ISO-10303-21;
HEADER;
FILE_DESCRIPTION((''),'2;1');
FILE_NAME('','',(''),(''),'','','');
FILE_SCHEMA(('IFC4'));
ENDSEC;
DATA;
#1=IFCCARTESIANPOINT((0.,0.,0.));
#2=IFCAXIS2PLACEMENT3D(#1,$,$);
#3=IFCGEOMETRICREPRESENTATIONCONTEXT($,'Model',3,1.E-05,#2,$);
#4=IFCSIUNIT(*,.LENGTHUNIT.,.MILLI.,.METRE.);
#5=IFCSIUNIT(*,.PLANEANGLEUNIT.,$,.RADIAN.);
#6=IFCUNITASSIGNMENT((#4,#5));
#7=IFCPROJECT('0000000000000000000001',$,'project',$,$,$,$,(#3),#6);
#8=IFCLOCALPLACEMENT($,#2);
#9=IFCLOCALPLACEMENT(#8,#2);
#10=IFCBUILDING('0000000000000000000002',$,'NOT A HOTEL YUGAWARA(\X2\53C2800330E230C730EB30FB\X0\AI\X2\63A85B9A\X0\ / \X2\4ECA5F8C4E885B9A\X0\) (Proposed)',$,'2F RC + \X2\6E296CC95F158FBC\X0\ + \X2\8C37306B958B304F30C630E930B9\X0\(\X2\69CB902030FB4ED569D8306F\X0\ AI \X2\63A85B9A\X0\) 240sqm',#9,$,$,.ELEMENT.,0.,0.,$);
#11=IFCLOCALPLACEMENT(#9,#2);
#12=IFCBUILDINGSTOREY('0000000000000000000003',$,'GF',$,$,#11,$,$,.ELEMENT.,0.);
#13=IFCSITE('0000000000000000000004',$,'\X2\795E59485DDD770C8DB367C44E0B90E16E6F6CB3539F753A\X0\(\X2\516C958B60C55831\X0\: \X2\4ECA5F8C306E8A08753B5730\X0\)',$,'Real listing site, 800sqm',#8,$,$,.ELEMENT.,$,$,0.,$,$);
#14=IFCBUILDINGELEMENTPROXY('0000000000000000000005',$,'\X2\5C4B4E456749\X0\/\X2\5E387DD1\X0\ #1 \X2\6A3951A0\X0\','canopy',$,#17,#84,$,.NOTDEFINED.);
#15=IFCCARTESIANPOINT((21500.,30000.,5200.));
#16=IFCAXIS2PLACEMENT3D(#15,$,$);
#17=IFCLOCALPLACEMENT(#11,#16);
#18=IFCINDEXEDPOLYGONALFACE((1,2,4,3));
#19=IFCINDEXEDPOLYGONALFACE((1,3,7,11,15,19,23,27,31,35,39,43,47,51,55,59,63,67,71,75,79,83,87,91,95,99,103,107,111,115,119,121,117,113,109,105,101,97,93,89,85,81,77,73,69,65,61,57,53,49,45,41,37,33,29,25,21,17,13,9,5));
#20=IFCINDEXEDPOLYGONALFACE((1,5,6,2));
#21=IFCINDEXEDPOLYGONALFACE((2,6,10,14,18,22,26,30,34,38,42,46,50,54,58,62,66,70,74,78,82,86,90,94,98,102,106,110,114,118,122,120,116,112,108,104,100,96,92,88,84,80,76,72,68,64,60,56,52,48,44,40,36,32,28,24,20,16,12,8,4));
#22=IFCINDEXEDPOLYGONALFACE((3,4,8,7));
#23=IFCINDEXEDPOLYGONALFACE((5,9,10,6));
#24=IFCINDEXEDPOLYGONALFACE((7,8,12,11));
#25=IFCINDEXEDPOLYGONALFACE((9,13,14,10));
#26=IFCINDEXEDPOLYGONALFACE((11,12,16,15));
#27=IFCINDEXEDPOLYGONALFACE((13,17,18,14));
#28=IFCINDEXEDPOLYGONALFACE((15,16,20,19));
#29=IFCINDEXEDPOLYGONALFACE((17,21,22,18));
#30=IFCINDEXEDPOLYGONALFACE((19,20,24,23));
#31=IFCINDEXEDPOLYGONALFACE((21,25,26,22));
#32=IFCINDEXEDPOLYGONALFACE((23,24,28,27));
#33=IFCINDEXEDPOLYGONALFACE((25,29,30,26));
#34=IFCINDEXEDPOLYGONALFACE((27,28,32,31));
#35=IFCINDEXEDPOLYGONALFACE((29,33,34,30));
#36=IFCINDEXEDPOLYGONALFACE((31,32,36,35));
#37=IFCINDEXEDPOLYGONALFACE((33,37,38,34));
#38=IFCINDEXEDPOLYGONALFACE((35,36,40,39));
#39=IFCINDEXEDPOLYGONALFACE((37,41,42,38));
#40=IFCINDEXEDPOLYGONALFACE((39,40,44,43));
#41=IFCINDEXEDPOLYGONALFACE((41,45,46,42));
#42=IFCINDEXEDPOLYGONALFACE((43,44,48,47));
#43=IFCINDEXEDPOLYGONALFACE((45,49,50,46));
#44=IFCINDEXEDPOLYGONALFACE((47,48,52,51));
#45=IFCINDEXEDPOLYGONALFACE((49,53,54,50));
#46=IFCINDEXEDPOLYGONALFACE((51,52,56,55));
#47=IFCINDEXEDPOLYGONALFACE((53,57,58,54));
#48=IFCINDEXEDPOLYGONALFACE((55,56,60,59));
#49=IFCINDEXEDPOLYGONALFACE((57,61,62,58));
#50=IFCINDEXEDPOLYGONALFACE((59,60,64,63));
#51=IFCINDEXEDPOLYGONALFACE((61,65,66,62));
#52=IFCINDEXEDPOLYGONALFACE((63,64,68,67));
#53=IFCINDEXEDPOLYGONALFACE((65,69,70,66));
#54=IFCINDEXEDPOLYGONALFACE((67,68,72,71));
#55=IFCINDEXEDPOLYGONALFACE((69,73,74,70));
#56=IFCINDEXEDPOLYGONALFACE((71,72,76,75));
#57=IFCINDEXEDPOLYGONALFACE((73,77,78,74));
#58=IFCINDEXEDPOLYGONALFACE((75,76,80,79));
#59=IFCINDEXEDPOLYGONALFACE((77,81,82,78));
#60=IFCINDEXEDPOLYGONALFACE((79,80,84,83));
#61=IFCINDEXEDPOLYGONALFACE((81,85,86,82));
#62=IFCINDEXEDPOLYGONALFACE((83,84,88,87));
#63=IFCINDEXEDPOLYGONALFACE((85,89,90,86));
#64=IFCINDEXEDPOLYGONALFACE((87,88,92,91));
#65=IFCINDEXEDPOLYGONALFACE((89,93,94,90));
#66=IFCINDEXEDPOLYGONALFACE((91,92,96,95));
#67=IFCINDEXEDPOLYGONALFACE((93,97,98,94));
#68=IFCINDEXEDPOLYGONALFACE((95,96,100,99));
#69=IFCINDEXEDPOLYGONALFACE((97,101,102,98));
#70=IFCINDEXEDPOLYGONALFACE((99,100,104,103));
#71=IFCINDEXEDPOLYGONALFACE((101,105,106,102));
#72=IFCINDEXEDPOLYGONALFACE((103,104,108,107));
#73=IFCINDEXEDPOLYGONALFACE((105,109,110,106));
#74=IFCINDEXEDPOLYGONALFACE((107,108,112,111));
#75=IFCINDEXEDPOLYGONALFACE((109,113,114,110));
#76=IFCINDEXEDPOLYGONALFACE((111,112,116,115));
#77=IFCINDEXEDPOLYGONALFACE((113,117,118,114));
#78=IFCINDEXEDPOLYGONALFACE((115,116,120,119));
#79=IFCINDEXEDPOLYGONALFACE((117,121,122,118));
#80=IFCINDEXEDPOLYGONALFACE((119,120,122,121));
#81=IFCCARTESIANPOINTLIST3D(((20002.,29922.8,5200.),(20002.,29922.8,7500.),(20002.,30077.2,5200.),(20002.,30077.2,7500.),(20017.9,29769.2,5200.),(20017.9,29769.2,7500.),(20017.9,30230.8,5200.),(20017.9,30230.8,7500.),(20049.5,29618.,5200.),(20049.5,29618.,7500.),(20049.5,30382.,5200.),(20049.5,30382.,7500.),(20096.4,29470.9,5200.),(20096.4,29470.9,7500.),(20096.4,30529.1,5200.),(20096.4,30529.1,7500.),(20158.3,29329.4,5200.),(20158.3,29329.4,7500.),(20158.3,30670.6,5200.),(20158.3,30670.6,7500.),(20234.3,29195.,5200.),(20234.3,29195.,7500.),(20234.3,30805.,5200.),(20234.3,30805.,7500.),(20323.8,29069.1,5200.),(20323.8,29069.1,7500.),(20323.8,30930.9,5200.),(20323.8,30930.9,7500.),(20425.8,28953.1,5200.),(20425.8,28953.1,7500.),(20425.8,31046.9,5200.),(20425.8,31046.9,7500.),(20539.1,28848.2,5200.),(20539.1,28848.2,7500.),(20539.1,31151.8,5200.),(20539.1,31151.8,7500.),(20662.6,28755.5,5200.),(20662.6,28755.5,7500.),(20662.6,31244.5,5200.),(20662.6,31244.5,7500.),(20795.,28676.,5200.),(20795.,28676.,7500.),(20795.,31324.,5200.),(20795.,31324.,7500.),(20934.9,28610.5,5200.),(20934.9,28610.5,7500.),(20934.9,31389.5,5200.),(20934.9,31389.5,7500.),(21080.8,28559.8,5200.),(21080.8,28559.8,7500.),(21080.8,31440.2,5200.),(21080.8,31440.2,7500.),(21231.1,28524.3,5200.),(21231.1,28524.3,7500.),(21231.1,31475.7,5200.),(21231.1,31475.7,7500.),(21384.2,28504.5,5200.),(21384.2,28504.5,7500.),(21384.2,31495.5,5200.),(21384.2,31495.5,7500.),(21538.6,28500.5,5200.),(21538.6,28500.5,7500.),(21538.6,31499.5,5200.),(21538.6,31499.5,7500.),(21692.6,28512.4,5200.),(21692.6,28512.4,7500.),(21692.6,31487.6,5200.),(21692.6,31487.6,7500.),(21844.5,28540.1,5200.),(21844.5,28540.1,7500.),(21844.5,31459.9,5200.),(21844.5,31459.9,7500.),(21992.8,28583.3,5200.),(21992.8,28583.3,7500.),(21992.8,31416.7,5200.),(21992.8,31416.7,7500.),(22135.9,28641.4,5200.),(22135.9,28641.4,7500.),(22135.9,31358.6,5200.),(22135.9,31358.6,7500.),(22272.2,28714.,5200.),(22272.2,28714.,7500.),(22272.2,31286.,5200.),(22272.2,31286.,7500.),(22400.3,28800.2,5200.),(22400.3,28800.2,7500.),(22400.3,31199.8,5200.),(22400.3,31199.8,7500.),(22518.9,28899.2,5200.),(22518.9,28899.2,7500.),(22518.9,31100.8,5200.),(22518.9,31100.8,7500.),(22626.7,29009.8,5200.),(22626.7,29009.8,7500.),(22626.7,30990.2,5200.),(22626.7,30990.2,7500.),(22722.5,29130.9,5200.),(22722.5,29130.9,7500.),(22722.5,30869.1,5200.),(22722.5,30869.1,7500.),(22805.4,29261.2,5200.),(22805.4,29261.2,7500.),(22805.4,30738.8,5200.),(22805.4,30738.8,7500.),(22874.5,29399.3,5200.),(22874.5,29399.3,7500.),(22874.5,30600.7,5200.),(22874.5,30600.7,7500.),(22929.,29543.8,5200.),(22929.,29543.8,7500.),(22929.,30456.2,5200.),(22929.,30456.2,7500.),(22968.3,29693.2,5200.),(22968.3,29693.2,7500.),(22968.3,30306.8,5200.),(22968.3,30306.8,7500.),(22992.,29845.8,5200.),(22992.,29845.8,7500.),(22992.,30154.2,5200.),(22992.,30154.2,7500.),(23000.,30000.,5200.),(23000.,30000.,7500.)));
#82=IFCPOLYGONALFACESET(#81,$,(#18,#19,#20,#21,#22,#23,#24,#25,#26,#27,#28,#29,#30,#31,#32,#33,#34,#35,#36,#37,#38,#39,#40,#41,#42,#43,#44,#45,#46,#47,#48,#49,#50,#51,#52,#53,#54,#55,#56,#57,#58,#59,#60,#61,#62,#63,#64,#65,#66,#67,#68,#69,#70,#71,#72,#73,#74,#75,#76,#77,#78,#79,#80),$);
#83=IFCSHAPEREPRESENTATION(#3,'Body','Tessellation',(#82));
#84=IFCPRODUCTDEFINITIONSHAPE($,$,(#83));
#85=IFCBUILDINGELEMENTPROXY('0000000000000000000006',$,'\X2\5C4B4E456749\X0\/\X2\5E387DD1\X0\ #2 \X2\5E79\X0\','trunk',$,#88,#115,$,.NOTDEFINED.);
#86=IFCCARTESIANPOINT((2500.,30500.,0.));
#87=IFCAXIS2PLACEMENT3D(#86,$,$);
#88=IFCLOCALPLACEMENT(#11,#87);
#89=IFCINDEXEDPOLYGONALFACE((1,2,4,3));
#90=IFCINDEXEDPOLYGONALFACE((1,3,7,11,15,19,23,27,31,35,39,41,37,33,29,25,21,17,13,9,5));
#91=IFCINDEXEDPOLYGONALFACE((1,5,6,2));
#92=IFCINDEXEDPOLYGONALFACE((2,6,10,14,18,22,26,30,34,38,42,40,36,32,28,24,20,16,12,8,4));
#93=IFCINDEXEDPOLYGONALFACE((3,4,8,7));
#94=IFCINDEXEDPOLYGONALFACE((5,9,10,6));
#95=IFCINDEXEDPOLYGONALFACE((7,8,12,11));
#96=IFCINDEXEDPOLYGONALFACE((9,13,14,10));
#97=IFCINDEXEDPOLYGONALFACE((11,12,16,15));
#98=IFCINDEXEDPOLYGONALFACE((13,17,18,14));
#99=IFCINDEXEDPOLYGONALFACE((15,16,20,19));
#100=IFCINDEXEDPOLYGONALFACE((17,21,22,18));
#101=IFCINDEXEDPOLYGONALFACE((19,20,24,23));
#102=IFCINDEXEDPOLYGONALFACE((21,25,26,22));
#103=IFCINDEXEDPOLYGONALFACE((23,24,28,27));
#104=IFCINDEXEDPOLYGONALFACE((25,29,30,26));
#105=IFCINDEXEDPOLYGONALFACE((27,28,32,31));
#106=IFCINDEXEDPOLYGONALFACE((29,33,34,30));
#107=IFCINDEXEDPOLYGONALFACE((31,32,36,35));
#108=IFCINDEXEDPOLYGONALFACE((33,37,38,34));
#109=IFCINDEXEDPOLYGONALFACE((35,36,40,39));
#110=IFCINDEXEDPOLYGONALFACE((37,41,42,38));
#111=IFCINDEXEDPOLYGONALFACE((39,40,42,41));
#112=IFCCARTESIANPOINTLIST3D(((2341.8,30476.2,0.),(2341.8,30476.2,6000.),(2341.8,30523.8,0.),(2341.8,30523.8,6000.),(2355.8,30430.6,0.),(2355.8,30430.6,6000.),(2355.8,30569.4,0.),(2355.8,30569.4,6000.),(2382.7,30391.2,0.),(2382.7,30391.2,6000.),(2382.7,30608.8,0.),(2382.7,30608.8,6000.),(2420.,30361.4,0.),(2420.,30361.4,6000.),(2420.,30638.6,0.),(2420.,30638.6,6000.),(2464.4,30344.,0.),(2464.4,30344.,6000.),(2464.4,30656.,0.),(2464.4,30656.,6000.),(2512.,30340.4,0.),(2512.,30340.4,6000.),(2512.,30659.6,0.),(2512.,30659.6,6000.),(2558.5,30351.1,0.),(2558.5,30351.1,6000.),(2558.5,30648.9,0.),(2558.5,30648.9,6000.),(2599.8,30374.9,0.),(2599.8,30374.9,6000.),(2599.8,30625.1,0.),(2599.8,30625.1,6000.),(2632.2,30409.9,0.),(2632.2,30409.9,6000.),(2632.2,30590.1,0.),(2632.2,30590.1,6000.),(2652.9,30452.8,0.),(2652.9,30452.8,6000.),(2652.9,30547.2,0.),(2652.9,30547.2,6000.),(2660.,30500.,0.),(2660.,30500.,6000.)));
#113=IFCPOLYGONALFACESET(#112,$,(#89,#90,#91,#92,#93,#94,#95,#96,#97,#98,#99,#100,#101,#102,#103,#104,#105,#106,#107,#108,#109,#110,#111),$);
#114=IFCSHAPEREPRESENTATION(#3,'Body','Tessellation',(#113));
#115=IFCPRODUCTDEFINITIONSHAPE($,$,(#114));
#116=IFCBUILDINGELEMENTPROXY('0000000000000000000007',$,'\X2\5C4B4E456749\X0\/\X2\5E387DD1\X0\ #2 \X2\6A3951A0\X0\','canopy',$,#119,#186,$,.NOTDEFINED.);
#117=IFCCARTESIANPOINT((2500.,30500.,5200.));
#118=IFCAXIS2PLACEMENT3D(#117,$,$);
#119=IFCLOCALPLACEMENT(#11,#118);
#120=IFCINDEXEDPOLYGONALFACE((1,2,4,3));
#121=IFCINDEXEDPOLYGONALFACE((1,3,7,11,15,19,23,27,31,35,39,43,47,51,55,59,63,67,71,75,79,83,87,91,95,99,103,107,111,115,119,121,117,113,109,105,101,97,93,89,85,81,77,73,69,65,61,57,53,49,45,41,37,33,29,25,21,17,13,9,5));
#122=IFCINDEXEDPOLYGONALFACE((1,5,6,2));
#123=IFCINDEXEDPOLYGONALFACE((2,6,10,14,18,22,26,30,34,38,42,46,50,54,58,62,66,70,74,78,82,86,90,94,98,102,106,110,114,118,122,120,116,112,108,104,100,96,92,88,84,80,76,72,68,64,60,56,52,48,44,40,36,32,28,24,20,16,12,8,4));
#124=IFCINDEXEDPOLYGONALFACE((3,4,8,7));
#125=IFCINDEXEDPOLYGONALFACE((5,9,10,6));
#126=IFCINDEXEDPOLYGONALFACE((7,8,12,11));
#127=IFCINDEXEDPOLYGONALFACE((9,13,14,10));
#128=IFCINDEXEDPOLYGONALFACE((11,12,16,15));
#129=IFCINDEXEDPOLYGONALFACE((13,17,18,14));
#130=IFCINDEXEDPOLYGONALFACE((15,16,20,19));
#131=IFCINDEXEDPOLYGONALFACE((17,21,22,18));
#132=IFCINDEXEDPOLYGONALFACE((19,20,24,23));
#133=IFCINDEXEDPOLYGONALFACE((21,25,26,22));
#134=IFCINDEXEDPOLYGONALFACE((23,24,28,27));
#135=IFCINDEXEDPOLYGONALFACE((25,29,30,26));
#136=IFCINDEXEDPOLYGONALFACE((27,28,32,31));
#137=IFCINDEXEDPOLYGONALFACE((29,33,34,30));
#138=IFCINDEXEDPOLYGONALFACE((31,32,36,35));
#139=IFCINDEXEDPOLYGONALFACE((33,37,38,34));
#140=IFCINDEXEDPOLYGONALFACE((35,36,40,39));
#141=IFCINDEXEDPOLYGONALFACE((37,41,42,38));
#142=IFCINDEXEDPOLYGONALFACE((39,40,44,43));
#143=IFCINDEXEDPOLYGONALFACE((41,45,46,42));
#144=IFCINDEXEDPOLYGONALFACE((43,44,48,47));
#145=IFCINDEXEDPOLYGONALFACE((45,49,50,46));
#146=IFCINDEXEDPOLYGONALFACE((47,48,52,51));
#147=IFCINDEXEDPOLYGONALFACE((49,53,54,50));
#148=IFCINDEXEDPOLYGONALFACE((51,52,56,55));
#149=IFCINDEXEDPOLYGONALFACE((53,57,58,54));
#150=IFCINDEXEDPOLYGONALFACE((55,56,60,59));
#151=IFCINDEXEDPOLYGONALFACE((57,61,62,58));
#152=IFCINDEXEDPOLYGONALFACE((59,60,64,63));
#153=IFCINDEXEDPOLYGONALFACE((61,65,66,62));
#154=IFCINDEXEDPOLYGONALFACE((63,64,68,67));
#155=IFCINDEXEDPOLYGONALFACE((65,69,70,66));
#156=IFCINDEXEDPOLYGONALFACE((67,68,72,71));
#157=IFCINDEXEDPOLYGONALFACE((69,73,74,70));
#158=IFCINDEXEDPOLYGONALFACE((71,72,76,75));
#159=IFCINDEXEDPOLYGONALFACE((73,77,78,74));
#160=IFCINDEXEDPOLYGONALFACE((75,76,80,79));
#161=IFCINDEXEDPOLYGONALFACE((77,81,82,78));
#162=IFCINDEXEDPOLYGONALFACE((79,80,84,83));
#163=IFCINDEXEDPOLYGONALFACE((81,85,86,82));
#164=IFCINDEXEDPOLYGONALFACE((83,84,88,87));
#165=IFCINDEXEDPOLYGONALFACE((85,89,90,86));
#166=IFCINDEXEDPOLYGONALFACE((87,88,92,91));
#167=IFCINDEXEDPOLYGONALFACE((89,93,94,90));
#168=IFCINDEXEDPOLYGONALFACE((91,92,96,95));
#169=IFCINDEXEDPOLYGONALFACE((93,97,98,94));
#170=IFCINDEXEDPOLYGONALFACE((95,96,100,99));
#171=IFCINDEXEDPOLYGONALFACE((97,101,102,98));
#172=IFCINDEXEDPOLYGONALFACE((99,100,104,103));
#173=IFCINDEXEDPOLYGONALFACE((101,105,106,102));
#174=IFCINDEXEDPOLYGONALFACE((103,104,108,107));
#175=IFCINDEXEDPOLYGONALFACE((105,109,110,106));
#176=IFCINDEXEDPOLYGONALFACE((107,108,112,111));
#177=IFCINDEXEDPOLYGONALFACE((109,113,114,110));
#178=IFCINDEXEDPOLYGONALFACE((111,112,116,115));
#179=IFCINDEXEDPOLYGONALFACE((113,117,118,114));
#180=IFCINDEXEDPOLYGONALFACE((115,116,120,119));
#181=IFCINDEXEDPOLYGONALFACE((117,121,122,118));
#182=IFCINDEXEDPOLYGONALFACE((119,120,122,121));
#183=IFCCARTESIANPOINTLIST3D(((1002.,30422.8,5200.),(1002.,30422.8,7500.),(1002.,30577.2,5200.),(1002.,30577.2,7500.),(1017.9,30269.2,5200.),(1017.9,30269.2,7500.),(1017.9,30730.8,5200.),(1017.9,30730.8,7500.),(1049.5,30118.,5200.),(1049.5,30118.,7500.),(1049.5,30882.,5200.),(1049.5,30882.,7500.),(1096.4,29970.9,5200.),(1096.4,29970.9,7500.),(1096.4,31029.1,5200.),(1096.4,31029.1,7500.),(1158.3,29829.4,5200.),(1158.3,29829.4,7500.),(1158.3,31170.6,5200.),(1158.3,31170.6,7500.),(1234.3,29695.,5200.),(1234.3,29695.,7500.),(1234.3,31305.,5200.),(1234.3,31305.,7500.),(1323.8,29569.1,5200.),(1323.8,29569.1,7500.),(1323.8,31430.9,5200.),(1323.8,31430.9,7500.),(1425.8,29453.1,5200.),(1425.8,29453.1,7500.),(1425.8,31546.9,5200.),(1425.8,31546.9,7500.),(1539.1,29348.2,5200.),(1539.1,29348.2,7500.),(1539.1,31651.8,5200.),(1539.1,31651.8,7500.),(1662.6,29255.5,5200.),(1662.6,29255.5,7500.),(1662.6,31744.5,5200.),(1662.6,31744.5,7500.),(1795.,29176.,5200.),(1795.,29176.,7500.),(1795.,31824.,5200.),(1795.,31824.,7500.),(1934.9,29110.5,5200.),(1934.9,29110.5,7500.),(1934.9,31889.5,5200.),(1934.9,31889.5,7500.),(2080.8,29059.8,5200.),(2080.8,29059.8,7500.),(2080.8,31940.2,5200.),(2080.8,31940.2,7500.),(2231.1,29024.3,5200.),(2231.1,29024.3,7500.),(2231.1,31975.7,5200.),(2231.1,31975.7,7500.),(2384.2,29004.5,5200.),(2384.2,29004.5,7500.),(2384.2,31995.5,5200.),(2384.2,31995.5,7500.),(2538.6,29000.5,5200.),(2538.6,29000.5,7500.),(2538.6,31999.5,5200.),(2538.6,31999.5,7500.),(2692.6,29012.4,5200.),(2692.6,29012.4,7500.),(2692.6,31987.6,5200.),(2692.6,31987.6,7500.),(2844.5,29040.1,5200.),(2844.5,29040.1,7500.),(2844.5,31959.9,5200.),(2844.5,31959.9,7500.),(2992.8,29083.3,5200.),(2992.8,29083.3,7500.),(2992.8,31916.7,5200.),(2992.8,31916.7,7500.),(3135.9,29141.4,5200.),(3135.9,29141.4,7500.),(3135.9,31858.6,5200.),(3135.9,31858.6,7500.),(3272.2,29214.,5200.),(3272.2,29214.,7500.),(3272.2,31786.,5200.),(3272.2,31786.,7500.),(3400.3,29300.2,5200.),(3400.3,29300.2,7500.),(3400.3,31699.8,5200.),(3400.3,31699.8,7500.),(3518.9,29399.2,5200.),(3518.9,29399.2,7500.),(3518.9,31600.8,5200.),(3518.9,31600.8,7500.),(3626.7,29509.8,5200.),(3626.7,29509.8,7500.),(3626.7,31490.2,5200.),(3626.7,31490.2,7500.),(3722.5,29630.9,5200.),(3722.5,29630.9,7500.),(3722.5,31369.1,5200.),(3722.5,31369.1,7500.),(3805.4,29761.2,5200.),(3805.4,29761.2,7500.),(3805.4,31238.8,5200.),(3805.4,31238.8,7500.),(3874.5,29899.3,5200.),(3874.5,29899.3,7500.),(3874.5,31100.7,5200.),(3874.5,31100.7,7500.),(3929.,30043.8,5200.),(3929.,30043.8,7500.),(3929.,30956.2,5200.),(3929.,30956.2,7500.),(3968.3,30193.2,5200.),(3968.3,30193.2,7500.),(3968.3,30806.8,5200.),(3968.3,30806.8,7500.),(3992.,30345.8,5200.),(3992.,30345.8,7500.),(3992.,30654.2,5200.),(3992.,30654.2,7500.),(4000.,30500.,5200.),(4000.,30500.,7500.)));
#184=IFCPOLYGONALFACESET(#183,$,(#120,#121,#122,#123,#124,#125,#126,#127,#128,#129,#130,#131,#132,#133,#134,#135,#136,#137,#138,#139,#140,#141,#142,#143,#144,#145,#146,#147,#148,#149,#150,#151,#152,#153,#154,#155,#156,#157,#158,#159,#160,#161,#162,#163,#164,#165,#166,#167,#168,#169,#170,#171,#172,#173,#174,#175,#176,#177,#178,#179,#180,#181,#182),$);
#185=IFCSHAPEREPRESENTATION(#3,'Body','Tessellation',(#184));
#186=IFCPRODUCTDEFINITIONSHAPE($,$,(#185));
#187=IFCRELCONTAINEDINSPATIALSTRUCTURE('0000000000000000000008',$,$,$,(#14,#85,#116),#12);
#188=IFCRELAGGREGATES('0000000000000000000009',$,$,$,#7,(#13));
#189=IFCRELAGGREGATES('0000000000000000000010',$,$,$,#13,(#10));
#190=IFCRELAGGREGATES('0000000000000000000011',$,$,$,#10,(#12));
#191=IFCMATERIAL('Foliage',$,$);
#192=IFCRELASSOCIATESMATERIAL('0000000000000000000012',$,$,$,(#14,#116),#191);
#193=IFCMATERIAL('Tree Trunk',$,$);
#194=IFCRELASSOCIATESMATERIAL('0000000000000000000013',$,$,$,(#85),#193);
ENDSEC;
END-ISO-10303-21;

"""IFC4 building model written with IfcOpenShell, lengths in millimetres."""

from ifc_helpers import new_model, si_unit, frame, origin, origin_2d, place, context, project, spatial, circle, extrude, material, element, save


model = new_model("IFC4")

# Units and contexts
model_context = context("Model", 3, precision=1e-05, world=origin())
ifc_project = project(units=[si_unit("LENGTHUNIT", "METRE", prefix="MILLI"), si_unit("PLANEANGLEUNIT", "RADIAN")], contexts=[model_context])

# Site, building, storey
site_placement = place(None, origin())
site = spatial("IfcSite", under=ifc_project, at=site_placement, Name="神奈川県足柄下郡湯河原町(公開情報: 今後の計画地)", ObjectType="Real listing site, 800sqm", CompositionType="ELEMENT", RefElevation=0.0)
building_placement = place(site_placement, origin())
building = spatial("IfcBuilding", under=site, at=building_placement, Name="NOT A HOTEL YUGAWARA(参考モデル・AI推定 / 今後予定) (Proposed)", ObjectType="2F RC + 温泉引込 + 谷に開くテラス(構造・仕様は AI 推定) 240sqm", CompositionType="ELEMENT", ElevationOfRefHeight=0.0, ElevationOfTerrain=0.0)
storey_placement = place(building_placement, origin())
storey = spatial("IfcBuildingStorey", under=building, at=storey_placement, Name="GF", CompositionType="ELEMENT", Elevation=0.0)

# Building element proxies
ifc_material_1 = material(Name="Tree Trunk")
ifc_material_2 = material(Name="Foliage")
proxy_1_placement = place(storey_placement, frame((21500.0, 30000.0, 5200.0)))
element("IfcBuildingElementProxy", 1, at=proxy_1_placement, inside=storey, material=ifc_material_2, Name="屋久杉/常緑 #1 樹冠", Description="canopy", PredefinedType="NOTDEFINED", context=model_context, shape_type="SweptSolid", body=[
    extrude(circle(Radius=1500.0, at=origin_2d()), frame((21500.0, 30000.0, 5200.0)), (0.0, 0.0, 1.0), 2300.0),
])
proxy_2_placement = place(storey_placement, frame((2500.0, 30500.0, 0.0)))
element("IfcBuildingElementProxy", 2, at=proxy_2_placement, inside=storey, material=ifc_material_1, Name="屋久杉/常緑 #2 幹", Description="trunk", PredefinedType="NOTDEFINED", context=model_context, shape_type="SweptSolid", body=[
    extrude(circle(Radius=160.0, at=origin_2d()), frame((2500.0, 30500.0, 0.0)), (0.0, 0.0, 1.0), 6000.0),
])
proxy_3_placement = place(storey_placement, frame((2500.0, 30500.0, 5200.0)))
element("IfcBuildingElementProxy", 3, at=proxy_3_placement, inside=storey, material=ifc_material_2, Name="屋久杉/常緑 #2 樹冠", Description="canopy", PredefinedType="NOTDEFINED", context=model_context, shape_type="SweptSolid", body=[
    extrude(circle(Radius=1500.0, at=origin_2d()), frame((2500.0, 30500.0, 5200.0)), (0.0, 0.0, 1.0), 2300.0),
])

save(model, "model.ifc")
